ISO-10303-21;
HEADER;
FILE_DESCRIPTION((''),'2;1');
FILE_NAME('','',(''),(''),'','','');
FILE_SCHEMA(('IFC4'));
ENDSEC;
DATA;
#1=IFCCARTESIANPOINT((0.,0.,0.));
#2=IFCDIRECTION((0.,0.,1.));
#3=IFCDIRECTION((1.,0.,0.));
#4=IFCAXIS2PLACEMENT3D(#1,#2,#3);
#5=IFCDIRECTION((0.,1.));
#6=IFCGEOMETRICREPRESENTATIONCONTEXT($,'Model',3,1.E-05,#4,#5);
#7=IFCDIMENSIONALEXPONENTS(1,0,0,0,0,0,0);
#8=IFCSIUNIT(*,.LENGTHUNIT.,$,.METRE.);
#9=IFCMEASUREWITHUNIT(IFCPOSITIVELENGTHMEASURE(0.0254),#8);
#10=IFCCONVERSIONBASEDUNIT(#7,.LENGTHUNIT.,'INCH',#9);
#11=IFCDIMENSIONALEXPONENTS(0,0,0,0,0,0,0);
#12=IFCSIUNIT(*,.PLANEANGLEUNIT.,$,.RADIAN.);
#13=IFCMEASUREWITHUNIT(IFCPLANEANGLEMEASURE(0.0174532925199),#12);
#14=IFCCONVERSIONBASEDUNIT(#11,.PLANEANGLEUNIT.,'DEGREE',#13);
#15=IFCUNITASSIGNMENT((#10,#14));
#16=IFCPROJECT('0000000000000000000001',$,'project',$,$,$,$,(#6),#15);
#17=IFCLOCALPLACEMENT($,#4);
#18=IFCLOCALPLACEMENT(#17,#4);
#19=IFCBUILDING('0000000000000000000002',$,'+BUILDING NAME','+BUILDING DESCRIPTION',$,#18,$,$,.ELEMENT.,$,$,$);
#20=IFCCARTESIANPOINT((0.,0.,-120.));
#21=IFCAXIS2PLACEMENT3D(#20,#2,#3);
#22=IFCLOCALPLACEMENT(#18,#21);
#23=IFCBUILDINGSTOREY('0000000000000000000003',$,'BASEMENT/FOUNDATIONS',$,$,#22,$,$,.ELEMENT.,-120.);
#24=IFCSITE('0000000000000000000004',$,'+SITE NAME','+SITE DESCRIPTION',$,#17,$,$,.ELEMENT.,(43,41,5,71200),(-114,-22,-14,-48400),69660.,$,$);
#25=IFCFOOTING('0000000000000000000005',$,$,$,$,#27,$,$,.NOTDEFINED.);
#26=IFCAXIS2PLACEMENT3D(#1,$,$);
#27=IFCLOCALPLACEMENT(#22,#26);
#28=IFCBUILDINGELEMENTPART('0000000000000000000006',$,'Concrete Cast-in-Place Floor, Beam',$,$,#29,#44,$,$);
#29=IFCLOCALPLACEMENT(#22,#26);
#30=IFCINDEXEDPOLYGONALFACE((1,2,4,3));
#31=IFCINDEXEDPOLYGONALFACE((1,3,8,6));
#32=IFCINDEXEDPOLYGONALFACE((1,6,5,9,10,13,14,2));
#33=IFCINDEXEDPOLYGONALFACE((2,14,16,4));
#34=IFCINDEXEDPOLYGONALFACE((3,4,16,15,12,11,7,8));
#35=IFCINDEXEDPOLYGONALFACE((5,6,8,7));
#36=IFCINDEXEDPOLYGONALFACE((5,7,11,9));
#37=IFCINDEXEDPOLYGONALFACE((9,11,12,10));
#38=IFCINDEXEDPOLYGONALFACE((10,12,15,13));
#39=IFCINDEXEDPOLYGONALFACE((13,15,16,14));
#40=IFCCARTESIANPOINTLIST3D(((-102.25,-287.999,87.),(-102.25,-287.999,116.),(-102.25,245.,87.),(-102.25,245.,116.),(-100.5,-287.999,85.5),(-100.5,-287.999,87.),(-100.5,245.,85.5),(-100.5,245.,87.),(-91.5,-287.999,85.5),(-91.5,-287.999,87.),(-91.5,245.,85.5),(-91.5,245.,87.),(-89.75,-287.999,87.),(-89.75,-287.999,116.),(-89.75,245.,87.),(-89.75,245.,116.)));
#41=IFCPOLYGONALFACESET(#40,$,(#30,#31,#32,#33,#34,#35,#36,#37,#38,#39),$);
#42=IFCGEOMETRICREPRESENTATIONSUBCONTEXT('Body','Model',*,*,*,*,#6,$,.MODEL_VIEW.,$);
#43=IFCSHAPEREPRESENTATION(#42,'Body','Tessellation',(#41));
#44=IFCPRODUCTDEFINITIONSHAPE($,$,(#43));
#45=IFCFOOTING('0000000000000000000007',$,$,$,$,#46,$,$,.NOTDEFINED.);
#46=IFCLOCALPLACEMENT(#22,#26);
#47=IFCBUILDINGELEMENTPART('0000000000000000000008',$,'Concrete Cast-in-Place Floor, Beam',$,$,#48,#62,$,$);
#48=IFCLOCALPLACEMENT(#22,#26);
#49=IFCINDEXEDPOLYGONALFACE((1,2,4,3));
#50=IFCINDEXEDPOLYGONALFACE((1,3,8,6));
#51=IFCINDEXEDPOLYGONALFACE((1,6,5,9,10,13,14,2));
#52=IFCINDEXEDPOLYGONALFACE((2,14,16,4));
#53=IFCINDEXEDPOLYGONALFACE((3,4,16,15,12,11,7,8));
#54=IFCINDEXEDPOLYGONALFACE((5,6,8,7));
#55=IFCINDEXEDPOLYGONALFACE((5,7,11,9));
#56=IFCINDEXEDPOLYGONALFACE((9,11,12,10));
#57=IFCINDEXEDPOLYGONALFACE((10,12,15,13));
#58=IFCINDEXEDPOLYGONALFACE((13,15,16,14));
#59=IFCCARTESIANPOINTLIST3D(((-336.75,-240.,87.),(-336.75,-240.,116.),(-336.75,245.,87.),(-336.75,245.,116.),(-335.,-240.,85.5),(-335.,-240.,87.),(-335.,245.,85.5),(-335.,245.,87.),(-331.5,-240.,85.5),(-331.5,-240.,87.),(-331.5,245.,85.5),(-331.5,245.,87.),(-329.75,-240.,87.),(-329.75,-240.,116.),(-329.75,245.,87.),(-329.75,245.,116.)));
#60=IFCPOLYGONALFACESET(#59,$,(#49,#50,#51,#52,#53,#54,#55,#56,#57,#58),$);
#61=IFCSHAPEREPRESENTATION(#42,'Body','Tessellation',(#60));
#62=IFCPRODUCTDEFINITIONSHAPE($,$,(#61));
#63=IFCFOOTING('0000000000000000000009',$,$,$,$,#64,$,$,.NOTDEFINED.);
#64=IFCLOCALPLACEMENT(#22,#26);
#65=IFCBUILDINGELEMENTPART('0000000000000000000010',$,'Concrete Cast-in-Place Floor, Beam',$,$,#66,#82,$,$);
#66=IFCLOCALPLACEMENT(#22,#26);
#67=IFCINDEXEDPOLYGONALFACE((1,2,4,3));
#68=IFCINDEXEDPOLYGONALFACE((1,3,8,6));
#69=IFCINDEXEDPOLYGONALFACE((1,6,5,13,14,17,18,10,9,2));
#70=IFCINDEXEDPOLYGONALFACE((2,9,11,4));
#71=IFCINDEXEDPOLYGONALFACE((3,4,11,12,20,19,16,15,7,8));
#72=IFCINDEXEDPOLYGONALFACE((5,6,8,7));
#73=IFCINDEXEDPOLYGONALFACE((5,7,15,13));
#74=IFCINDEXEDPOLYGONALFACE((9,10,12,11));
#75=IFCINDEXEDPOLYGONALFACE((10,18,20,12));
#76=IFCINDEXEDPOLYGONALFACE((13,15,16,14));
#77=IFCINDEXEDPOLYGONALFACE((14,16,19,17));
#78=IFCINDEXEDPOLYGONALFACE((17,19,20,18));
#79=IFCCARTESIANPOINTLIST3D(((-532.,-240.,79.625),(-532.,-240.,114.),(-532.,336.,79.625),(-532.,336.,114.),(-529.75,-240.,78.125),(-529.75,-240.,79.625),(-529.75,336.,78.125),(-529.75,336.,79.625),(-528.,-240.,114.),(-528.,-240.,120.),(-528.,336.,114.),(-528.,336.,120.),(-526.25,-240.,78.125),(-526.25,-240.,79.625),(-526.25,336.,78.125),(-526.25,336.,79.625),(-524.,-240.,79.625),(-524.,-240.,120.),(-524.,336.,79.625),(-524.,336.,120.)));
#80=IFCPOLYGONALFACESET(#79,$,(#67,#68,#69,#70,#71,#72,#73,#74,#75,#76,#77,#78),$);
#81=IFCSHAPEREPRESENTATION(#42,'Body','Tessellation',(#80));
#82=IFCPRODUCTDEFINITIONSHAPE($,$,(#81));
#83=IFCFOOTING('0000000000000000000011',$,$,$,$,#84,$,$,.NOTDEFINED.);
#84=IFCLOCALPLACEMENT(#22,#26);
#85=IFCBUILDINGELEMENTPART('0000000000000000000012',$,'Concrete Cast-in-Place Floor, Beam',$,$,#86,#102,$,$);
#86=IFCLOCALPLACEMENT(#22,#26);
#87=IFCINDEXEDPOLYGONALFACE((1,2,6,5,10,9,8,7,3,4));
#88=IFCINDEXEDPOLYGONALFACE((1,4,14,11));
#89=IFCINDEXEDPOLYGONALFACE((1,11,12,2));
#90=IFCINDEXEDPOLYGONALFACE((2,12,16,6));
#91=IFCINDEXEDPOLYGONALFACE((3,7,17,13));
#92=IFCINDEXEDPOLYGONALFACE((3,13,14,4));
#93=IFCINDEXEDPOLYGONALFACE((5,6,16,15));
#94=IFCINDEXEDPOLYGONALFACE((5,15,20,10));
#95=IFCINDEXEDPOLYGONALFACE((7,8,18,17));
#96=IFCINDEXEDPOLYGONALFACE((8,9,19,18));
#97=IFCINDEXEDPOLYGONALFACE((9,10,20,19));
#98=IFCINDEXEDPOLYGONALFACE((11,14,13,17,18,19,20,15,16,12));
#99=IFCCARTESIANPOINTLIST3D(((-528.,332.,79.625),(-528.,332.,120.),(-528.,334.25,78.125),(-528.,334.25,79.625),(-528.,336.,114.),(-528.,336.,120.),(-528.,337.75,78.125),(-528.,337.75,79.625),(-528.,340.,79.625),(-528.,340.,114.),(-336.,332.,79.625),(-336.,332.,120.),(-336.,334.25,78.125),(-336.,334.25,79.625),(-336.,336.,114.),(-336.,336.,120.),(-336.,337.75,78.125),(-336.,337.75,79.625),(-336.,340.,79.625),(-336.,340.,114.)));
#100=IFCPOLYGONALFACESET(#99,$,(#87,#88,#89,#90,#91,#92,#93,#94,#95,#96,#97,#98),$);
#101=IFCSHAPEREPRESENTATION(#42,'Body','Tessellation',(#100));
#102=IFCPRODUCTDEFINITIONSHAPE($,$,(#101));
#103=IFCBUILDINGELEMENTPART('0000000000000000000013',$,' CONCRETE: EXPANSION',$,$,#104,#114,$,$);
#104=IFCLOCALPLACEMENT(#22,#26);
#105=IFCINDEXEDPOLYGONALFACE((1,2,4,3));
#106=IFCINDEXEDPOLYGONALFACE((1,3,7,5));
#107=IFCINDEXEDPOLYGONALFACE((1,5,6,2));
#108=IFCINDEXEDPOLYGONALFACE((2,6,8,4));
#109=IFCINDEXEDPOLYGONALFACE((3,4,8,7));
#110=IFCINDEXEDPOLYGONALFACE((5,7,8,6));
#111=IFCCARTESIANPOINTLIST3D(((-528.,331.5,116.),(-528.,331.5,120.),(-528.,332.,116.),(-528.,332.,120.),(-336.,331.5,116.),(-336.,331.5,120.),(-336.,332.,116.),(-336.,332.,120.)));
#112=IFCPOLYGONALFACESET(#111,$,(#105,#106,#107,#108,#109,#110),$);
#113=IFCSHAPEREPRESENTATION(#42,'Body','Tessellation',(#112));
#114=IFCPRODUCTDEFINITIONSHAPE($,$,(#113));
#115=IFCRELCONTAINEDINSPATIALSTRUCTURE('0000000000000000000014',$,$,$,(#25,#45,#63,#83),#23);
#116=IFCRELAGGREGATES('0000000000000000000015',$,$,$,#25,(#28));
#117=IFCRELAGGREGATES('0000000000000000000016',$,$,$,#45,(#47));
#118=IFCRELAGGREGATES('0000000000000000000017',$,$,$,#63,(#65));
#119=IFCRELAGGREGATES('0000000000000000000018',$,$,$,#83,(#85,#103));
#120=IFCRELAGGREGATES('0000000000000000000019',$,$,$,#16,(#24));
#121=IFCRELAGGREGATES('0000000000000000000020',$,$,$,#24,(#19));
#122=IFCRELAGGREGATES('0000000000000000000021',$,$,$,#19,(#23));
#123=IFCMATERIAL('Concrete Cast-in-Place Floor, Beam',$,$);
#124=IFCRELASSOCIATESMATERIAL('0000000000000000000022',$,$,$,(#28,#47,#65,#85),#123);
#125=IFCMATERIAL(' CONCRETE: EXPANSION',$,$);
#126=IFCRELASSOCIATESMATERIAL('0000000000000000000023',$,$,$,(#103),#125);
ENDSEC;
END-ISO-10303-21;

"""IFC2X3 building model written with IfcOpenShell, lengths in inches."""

from ifc_helpers import new_model, entity, si_unit, converted_unit, direction, frame, origin_with_axes, place, context, subcontext, project, spatial, polyline, outline, extrude, material, element, aggregate, save


model = new_model("IFC2X3")

# Units and contexts
model_context = context("Model", 3, precision=1e-05, world=origin_with_axes(), true_north=direction((0.0, 1.0)))
body_context = subcontext(model_context, "Body", "Model", "MODEL_VIEW")
ifc_project = project(units=[converted_unit("LENGTHUNIT", "INCH", entity("IfcPositiveLengthMeasure", 0.0254), si_unit("LENGTHUNIT", "METRE"), dimensions=[1, 0, 0, 0, 0, 0, 0]), converted_unit("PLANEANGLEUNIT", "DEGREE", entity("IfcPlaneAngleMeasure", 0.0174532925199), si_unit("PLANEANGLEUNIT", "RADIAN"), dimensions=[0, 0, 0, 0, 0, 0, 0])], contexts=[model_context])

# Site, building, storey
site_placement = place(None, origin_with_axes())
site = spatial("IfcSite", under=ifc_project, at=site_placement, Name="+SITE NAME", Description="+SITE DESCRIPTION", CompositionType="ELEMENT", RefLatitude=(43, 41, 5, 71200), RefLongitude=(-114, -22, -14, -48400), RefElevation=69660.0)
building_placement = place(site_placement, origin_with_axes())
building = spatial("IfcBuilding", under=site, at=building_placement, Name="+BUILDING NAME", Description="+BUILDING DESCRIPTION", CompositionType="ELEMENT")
storey_placement = place(building_placement, frame((0.0, 0.0, -120.0), z_axis=(0.0, 0.0, 1.0), x_axis=(1.0, 0.0, 0.0)))
storey = spatial("IfcBuildingStorey", under=building, at=storey_placement, Name="BASEMENT/FOUNDATIONS", CompositionType="ELEMENT", Elevation=-120.0)

# Footings, building element parts
footing_1_placement = place(storey_placement, frame((-96.0, 245.0, 116.0), z_axis=(0.0, 0.0, 1.0), x_axis=(0.0, -1.0, 0.0)))
footing_1 = element("IfcFooting", 1, at=footing_1_placement, inside=storey, PredefinedType="NOTDEFINED")
ifc_material_1 = material(Name="Concrete Cast-in-Place Floor, Beam")
building_element_part_1_placement = place(footing_1_placement, origin_with_axes())
building_element_part_1 = element("IfcBuildingElementPart", 2, at=building_element_part_1_placement, material=ifc_material_1, Name="Concrete Cast-in-Place Floor, Beam", context=body_context, shape_type="SweptSolid", body=[
    extrude(outline(polyline([(-6.25, 0.0), (-6.25, -29.0), (-4.5, -29.0), (-4.5, -30.5), (4.5, -30.5), (4.5, -29.0), (6.25, -29.0), (6.25, 0.0), (-6.25, 0.0)])), frame((0.0, 0.0, 0.0), z_axis=(1.0, 0.0, 0.0), x_axis=(0.0, 1.0, 0.0)), (0.0, 0.0, 1.0), 532.999),
])
aggregate(footing_1, [building_element_part_1])
ifc_material_2 = material(Name=" CONCRETE: EXPANSION")
footing_2_placement = place(storey_placement, frame((-336.0, 245.0, 116.0), z_axis=(0.0, 0.0, 1.0), x_axis=(0.0, -1.0, 0.0)))
footing_2 = element("IfcFooting", 3, at=footing_2_placement, inside=storey, PredefinedType="NOTDEFINED")
building_element_part_2_placement = place(footing_2_placement, origin_with_axes())
building_element_part_2 = element("IfcBuildingElementPart", 4, at=building_element_part_2_placement, material=ifc_material_1, Name="Concrete Cast-in-Place Floor, Beam", context=body_context, shape_type="SweptSolid", body=[
    extrude(outline(polyline([(-3.5, 0.0), (-3.5, -29.0), (-1.75, -29.0), (-1.75, -30.5), (1.75, -30.5), (1.75, -29.0), (3.5, -29.0), (3.5, 0.0), (-3.5, 0.0)])), frame((0.0, 2.75, 0.0), z_axis=(1.0, 0.0, 0.0), x_axis=(0.0, 1.0, 0.0)), (0.0, 0.0, 1.0), 485.0),
])
aggregate(footing_2, [building_element_part_2])
footing_3_placement = place(storey_placement, frame((-528.0, 336.0, 120.0), z_axis=(0.0, 0.0, 1.0), x_axis=(0.0, -1.0, 0.0)))
footing_3 = element("IfcFooting", 5, at=footing_3_placement, inside=storey, PredefinedType="NOTDEFINED")
building_element_part_3_placement = place(footing_3_placement, origin_with_axes())
building_element_part_3 = element("IfcBuildingElementPart", 6, at=building_element_part_3_placement, material=ifc_material_1, Name="Concrete Cast-in-Place Floor, Beam", context=body_context, shape_type="SweptSolid", body=[
    extrude(outline(polyline([(-4.0, 0.0), (-4.0, -40.375), (-1.75, -40.375), (-1.75, -41.875), (1.75, -41.875), (1.75, -40.375), (4.0, -40.375), (4.0, -6.0), (0.0, -6.0), (0.0, 0.0), (-4.0, 0.0)])), frame((0.0, 0.0, 0.0), z_axis=(-1.0, 0.0, 0.0), x_axis=(0.0, -1.0, 0.0)), (0.0, 0.0, -1.0), 576.0),
])
aggregate(footing_3, [building_element_part_3])
footing_4_placement = place(storey_placement, frame((-336.0, 336.0, 120.0), z_axis=(0.0, 0.0, 1.0), x_axis=(-1.0, 0.0, 0.0)))
footing_4 = element("IfcFooting", 7, at=footing_4_placement, inside=storey, PredefinedType="NOTDEFINED")
building_element_part_4_placement = place(footing_4_placement, origin_with_axes())
building_element_part_4 = element("IfcBuildingElementPart", 8, at=building_element_part_4_placement, material=ifc_material_1, Name="Concrete Cast-in-Place Floor, Beam", context=body_context, shape_type="SweptSolid", body=[
    extrude(outline(polyline([(-4.0, 0.0), (-4.0, -40.375), (-1.75, -40.375), (-1.75, -41.875), (1.75, -41.875), (1.75, -40.375), (4.0, -40.375), (4.0, -6.0), (0.0, -6.0), (0.0, 0.0), (-4.0, 0.0)])), frame((0.0, 0.0, 0.0), z_axis=(-1.0, 0.0, 0.0), x_axis=(0.0, -1.0, 0.0)), (0.0, 0.0, -1.0), 192.0),
])
building_element_part_5_placement = place(footing_4_placement, origin_with_axes())
building_element_part_5 = element("IfcBuildingElementPart", 9, at=building_element_part_5_placement, material=ifc_material_2, Name=" CONCRETE: EXPANSION", context=body_context, shape_type="SweptSolid", body=[
    extrude(outline(polyline([(-4.0, 0.0), (-4.5, 0.0), (-4.5, -4.0), (-4.0, -4.0), (-4.0, 0.0)])), frame((0.0, 0.0, 0.0), z_axis=(-1.0, 0.0, 0.0), x_axis=(0.0, -1.0, 0.0)), (0.0, 0.0, -1.0), 192.0),
])
aggregate(footing_4, [building_element_part_4, building_element_part_5])

save(model, "model.ifc")
